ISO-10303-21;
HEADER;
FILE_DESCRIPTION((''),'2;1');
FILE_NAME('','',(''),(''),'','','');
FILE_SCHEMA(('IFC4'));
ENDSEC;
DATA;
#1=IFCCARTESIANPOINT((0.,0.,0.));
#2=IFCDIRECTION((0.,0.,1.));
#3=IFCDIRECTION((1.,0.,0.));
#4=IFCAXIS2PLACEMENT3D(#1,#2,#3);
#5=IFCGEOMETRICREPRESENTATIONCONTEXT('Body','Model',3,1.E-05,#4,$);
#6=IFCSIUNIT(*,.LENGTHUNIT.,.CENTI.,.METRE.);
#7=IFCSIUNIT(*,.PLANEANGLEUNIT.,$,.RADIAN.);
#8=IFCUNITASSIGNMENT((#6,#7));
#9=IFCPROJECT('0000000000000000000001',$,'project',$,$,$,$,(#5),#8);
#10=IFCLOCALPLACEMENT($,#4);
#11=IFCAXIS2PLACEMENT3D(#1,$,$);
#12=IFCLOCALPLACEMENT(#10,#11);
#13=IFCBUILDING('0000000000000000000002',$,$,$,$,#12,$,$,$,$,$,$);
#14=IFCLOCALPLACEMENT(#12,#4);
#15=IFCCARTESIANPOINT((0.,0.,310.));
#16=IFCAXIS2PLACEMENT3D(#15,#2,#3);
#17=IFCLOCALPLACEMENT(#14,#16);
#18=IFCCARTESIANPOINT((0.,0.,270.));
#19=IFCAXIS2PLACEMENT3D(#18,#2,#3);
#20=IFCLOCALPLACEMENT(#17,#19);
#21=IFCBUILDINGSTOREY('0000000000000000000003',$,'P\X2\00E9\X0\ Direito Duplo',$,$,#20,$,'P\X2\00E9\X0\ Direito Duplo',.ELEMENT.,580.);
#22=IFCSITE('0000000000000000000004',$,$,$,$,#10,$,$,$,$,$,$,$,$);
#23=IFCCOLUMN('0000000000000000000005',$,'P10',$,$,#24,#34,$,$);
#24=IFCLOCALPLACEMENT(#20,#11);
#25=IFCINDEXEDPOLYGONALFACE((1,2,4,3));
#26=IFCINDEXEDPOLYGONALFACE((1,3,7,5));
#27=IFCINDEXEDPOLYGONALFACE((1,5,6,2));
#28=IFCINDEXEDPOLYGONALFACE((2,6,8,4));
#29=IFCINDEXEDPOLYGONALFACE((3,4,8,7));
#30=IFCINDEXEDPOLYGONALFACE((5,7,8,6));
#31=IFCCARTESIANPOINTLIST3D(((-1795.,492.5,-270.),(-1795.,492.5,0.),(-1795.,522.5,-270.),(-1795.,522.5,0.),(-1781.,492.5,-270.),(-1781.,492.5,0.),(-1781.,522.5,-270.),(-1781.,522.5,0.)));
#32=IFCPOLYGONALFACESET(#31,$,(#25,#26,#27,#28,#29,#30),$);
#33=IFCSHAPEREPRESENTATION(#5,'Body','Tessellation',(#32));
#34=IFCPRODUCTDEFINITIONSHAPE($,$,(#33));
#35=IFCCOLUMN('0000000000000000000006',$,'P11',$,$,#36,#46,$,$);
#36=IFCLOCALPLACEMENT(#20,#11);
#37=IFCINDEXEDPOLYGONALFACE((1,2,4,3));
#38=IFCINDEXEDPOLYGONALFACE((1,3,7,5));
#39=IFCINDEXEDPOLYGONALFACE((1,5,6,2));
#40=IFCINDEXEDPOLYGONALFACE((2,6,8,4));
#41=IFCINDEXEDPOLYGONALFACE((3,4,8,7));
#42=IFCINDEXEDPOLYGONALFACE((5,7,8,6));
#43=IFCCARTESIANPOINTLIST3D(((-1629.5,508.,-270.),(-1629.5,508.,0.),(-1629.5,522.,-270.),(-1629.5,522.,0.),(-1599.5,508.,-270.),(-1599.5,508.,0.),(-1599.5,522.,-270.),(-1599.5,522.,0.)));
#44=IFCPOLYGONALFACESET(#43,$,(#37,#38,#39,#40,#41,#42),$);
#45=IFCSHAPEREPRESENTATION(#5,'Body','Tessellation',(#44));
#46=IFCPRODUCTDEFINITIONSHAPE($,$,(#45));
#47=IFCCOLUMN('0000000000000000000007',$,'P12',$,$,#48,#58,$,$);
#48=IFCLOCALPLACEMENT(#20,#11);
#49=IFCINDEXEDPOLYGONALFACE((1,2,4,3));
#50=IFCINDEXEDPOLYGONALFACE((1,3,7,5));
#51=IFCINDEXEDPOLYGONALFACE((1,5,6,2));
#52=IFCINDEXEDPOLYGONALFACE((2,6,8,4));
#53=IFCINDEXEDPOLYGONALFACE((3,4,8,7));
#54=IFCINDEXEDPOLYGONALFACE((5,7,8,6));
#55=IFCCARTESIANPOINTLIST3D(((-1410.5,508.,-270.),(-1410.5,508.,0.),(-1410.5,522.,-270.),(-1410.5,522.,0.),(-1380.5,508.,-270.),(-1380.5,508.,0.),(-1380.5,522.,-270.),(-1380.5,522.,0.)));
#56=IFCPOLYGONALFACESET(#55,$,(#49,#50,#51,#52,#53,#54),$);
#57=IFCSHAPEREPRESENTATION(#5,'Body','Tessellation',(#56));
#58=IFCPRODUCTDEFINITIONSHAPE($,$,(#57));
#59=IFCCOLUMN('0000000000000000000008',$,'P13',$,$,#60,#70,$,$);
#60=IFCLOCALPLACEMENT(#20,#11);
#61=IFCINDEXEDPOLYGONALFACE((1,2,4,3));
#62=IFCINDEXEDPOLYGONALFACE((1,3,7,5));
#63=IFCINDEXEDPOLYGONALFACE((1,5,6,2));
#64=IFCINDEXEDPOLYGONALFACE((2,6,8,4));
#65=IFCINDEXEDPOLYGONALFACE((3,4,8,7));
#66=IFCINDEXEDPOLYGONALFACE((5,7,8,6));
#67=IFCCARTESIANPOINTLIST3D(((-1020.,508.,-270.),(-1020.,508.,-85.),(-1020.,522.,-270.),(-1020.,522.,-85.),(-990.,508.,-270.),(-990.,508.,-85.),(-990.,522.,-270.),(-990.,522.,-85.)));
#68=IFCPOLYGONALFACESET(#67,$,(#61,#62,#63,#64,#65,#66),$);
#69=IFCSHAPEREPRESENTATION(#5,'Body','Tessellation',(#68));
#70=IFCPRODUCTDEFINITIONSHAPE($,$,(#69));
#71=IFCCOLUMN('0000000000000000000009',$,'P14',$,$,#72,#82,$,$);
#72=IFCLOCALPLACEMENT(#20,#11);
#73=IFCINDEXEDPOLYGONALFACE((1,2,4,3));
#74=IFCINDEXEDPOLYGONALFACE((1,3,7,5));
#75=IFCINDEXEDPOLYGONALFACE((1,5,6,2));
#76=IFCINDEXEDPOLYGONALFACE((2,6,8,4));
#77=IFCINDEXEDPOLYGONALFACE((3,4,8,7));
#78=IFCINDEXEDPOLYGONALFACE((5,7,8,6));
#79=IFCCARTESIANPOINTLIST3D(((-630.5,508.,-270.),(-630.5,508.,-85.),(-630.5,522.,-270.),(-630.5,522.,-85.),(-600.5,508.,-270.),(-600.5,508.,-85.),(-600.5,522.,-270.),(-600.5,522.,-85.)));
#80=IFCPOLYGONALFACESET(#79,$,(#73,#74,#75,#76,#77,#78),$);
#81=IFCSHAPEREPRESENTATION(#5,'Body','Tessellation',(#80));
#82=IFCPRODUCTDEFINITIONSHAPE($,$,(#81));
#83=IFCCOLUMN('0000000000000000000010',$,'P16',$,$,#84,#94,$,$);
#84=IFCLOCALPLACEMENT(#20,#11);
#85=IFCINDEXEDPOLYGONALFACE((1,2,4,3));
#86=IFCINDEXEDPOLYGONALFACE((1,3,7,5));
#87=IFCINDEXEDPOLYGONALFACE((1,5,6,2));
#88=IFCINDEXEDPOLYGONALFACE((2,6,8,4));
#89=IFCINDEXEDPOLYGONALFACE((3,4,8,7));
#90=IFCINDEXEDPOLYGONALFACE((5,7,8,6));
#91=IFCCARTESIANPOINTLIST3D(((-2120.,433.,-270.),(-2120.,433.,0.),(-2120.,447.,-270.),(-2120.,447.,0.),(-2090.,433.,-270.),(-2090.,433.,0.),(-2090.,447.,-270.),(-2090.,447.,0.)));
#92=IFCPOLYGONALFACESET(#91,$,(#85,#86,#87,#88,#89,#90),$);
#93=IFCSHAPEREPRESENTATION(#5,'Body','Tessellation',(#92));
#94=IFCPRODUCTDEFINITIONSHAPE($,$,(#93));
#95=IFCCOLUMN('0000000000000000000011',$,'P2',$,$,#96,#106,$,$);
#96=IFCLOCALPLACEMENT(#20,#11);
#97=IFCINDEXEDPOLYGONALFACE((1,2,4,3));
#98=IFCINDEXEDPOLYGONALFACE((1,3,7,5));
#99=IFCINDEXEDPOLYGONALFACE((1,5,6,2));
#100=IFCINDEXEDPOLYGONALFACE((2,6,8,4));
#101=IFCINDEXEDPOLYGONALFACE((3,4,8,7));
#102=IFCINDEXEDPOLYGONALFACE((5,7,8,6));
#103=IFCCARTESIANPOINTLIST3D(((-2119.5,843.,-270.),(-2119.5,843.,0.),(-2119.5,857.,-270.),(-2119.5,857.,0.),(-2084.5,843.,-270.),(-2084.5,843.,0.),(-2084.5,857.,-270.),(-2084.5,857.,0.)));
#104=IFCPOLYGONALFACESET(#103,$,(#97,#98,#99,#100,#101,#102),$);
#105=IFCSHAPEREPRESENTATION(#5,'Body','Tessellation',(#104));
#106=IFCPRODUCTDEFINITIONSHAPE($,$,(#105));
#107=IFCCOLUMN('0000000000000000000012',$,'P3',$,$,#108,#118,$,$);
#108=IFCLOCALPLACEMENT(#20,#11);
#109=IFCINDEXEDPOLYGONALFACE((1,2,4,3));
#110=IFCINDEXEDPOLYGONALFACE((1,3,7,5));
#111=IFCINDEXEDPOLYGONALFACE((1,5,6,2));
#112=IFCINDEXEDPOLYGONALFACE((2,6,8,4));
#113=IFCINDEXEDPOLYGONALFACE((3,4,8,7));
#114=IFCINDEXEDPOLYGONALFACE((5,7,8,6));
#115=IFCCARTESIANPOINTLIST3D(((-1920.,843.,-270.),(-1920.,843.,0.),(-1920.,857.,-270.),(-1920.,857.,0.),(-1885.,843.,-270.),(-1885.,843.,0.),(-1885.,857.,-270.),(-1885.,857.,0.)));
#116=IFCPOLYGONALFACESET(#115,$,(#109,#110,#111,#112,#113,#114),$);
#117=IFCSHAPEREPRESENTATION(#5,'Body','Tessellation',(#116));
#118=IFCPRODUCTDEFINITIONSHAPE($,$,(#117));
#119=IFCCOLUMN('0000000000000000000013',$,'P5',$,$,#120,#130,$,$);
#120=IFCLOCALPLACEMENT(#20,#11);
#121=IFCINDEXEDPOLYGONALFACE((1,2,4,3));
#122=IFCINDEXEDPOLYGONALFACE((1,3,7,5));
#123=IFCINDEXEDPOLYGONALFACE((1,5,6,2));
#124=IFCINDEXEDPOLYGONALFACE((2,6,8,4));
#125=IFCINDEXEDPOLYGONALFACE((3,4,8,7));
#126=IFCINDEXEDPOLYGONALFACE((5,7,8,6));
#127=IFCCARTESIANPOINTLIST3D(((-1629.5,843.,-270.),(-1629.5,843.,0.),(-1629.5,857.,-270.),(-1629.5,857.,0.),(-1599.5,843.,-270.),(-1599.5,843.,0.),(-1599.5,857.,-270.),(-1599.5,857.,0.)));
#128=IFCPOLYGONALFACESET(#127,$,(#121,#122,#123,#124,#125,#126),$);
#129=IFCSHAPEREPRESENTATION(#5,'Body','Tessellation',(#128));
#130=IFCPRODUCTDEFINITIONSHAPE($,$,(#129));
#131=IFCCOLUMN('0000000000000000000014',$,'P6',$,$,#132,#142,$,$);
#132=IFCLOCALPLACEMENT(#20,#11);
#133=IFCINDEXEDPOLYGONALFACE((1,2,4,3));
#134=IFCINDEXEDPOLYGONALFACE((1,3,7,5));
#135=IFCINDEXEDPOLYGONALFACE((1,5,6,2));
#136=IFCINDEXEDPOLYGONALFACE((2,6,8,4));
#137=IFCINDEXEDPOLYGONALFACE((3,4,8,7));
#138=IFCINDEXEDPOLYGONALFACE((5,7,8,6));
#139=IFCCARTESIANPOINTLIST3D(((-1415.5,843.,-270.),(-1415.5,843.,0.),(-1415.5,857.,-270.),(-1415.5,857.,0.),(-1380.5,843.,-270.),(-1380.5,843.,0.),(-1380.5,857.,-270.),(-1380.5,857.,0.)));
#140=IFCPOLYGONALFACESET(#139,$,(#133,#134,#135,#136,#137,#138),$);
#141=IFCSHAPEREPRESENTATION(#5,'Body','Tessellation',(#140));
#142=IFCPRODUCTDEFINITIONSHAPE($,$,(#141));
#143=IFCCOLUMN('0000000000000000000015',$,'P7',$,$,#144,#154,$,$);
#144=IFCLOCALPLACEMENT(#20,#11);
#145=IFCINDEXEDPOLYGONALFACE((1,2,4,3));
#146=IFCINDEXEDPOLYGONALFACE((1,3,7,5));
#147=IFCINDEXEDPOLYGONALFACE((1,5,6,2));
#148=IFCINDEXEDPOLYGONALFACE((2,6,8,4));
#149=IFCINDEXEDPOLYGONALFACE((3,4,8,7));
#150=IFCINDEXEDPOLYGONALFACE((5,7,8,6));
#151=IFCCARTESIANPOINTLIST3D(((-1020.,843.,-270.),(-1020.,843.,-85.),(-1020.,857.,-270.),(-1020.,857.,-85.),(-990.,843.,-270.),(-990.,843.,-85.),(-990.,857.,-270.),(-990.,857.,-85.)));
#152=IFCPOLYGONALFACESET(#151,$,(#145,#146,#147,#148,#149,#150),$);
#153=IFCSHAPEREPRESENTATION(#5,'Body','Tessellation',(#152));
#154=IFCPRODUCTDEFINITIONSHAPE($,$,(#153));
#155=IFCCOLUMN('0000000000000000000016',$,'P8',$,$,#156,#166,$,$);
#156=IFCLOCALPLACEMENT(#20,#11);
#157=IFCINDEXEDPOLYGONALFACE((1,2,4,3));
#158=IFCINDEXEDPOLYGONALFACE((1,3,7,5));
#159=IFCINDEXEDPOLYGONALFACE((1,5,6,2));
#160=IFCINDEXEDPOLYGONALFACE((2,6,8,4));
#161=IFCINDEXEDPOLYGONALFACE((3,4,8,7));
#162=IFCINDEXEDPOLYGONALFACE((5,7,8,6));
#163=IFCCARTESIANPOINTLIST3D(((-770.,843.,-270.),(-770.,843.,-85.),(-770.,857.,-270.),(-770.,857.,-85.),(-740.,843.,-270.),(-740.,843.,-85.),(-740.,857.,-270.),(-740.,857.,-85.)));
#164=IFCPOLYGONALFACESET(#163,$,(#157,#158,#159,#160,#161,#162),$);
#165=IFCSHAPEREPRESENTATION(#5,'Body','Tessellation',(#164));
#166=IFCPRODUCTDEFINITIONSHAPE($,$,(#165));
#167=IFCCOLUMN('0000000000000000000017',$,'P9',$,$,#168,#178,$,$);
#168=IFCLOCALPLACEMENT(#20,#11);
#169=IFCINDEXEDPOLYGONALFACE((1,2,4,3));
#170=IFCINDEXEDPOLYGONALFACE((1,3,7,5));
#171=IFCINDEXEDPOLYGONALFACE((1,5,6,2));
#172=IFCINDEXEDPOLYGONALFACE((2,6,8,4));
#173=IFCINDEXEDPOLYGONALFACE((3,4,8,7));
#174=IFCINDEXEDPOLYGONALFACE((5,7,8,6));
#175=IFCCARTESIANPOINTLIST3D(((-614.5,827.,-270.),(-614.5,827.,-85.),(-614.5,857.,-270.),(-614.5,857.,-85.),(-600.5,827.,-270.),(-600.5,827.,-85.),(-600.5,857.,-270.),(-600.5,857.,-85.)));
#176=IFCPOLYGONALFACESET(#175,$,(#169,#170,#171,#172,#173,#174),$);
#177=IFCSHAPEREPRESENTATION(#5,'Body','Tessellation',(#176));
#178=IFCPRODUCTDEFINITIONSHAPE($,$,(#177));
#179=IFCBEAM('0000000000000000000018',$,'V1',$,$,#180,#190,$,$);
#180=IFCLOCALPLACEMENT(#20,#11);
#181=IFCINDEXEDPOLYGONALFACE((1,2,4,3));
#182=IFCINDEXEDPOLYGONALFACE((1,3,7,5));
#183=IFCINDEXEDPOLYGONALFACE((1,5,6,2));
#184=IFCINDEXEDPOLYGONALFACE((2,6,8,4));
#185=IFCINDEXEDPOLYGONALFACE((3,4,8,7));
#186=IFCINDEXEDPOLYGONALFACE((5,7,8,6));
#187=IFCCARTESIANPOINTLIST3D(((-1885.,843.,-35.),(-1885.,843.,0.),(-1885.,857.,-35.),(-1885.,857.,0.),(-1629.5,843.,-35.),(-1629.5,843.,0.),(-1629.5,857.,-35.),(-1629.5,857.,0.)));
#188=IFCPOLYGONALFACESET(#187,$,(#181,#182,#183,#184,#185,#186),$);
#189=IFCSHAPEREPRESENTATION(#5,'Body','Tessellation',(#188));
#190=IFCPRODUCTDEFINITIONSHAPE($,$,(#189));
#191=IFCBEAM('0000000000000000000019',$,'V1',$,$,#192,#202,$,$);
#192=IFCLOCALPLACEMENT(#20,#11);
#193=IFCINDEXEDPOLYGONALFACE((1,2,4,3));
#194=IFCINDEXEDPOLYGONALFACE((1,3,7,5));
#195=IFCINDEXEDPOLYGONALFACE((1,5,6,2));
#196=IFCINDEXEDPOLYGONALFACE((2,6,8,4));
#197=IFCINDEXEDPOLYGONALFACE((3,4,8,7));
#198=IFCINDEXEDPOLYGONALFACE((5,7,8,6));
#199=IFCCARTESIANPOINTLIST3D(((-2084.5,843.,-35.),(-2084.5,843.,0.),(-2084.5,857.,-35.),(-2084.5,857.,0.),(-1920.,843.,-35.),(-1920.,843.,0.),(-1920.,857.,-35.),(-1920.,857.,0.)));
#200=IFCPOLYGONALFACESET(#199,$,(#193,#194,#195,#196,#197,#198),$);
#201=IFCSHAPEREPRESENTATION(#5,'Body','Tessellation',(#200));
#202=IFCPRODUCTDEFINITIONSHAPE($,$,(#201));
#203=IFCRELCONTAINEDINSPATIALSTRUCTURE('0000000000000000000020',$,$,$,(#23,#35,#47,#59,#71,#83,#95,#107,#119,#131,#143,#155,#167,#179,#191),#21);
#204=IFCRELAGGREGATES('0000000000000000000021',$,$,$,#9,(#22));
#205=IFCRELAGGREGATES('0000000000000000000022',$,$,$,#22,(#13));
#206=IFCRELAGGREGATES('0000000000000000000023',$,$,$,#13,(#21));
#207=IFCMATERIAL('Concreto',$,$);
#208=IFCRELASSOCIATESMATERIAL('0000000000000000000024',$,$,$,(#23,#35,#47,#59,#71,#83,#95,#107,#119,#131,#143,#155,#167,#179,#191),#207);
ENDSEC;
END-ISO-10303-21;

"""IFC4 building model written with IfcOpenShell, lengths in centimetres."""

from ifc_helpers import new_model, si_unit, frame, origin, origin_with_axes, origin_2d_with_axis, place, context, project, spatial, rectangle, extrude, material, element, save


model = new_model("IFC4")

# Units and contexts
model_context = context("Model", 3, precision=1e-05, world=origin_with_axes(), identifier="Body")
ifc_project = project(units=[si_unit("LENGTHUNIT", "METRE", prefix="CENTI"), si_unit("PLANEANGLEUNIT", "RADIAN")], contexts=[model_context])

# Site, building, storey
site_placement = place(None, origin_with_axes())
site = spatial("IfcSite", under=ifc_project, at=site_placement)
building_placement = place(site_placement, origin())
building = spatial("IfcBuilding", under=site, at=building_placement)
placement_1 = place(building_placement, origin_with_axes())
placement_2 = place(placement_1, frame((0.0, 0.0, 310.0), z_axis=(0.0, 0.0, 1.0), x_axis=(1.0, 0.0, 0.0)))
storey_placement = place(placement_2, frame((0.0, 0.0, 270.0), z_axis=(0.0, 0.0, 1.0), x_axis=(1.0, 0.0, 0.0)))
storey = spatial("IfcBuildingStorey", under=building, at=storey_placement, Name="Pé Direito Duplo", LongName="Pé Direito Duplo", CompositionType="ELEMENT", Elevation=580.0)

# Columns
ifc_material = material(Name="Concreto")
column_1_placement = place(storey_placement, frame((-1788.0, 507.5, 0.0), z_axis=(0.0, 0.0, 1.0), x_axis=(1.0, 0.0, 0.0)))
element("IfcColumn", 1, at=column_1_placement, inside=storey, material=ifc_material, Name="P10", context=model_context, shape_type="SolidModel", body=[
    extrude(rectangle(XDim=14.0, YDim=30.0, at=origin_2d_with_axis()), origin_with_axes(), (0.0, 0.0, -1.0), 270.0),
])
for number, where, z_axis, x_axis, name in (
    (2, (-1614.5, 515.0, 0.0), (0.0, 0.0, 1.0), (1.0, 0.0, 0.0), "P11"),
    (3, (-1395.5, 515.0, 0.0), (0.0, 0.0, 1.0), (1.0, 0.0, 0.0), "P12"),
):
    element("IfcColumn", number, at=place(storey_placement, frame(where, z_axis=z_axis, x_axis=x_axis)), inside=storey, material=ifc_material, Name=name, context=model_context, shape_type="SolidModel", body=[
        extrude(rectangle(XDim=14.0, YDim=30.0, at=origin_2d_with_axis()), frame((0.0, 0.0, 0.0), z_axis=(0.0, 0.0, 1.0), x_axis=(0.0, 1.0, 0.0)), (0.0, 0.0, -1.0), 270.0),
    ])
for number, where, z_axis, x_axis, name in (
    (4, (-1005.0, 515.0, -85.0), (0.0, 0.0, 1.0), (1.0, 0.0, 0.0), "P13"),
    (5, (-615.5, 515.0, -85.0), (0.0, 0.0, 1.0), (1.0, 0.0, 0.0), "P14"),
):
    element("IfcColumn", number, at=place(storey_placement, frame(where, z_axis=z_axis, x_axis=x_axis)), inside=storey, material=ifc_material, Name=name, context=model_context, shape_type="SolidModel", body=[
        extrude(rectangle(XDim=14.0, YDim=30.0, at=origin_2d_with_axis()), frame((0.0, 0.0, 0.0), z_axis=(0.0, 0.0, 1.0), x_axis=(0.0, -1.0, 0.0)), (0.0, 0.0, -1.0), 185.0),
    ])
column_2_placement = place(storey_placement, frame((-2105.0, 440.0, 0.0), z_axis=(0.0, 0.0, 1.0), x_axis=(1.0, 0.0, 0.0)))
element("IfcColumn", 6, at=column_2_placement, inside=storey, material=ifc_material, Name="P16", context=model_context, shape_type="SolidModel", body=[
    extrude(rectangle(XDim=14.0, YDim=30.0, at=origin_2d_with_axis()), frame((0.0, 0.0, 0.0), z_axis=(0.0, 0.0, 1.0), x_axis=(0.0, 1.0, 0.0)), (0.0, 0.0, -1.0), 270.0),
])
column_3_placement = place(storey_placement, frame((-2102.0, 850.0, 0.0), z_axis=(0.0, 0.0, 1.0), x_axis=(1.0, 0.0, 0.0)))
element("IfcColumn", 7, at=column_3_placement, inside=storey, material=ifc_material, Name="P2", context=model_context, shape_type="SolidModel", body=[
    extrude(rectangle(XDim=14.0, YDim=35.0, at=origin_2d_with_axis()), frame((0.0, 0.0, 0.0), z_axis=(0.0, 0.0, 1.0), x_axis=(0.0, -1.0, 0.0)), (0.0, 0.0, -1.0), 270.0),
])
column_4_placement = place(storey_placement, frame((-1902.5, 850.0, 0.0), z_axis=(0.0, 0.0, 1.0), x_axis=(1.0, 0.0, 0.0)))
element("IfcColumn", 8, at=column_4_placement, inside=storey, material=ifc_material, Name="P3", context=model_context, shape_type="SolidModel", body=[
    extrude(rectangle(XDim=14.0, YDim=35.0, at=origin_2d_with_axis()), frame((0.0, 0.0, 0.0), z_axis=(0.0, 0.0, 1.0), x_axis=(0.0, 1.0, 0.0)), (0.0, 0.0, -1.0), 270.0),
])
column_5_placement = place(storey_placement, frame((-1614.5, 850.0, 0.0), z_axis=(0.0, 0.0, 1.0), x_axis=(1.0, 0.0, 0.0)))
element("IfcColumn", 9, at=column_5_placement, inside=storey, material=ifc_material, Name="P5", context=model_context, shape_type="SolidModel", body=[
    extrude(rectangle(XDim=14.0, YDim=30.0, at=origin_2d_with_axis()), frame((0.0, 0.0, 0.0), z_axis=(0.0, 0.0, 1.0), x_axis=(0.0, -1.0, 0.0)), (0.0, 0.0, -1.0), 270.0),
])
column_6_placement = place(storey_placement, frame((-1398.0, 850.0, 0.0), z_axis=(0.0, 0.0, 1.0), x_axis=(1.0, 0.0, 0.0)))
element("IfcColumn", 10, at=column_6_placement, inside=storey, material=ifc_material, Name="P6", context=model_context, shape_type="SolidModel", body=[
    extrude(rectangle(XDim=14.0, YDim=35.0, at=origin_2d_with_axis()), frame((0.0, 0.0, 0.0), z_axis=(0.0, 0.0, 1.0), x_axis=(0.0, 1.0, 0.0)), (0.0, 0.0, -1.0), 270.0),
])
for number, where, z_axis, x_axis, name in (
    (11, (-1005.0, 850.0, -85.0), (0.0, 0.0, 1.0), (1.0, 0.0, 0.0), "P7"),
    (12, (-755.0, 850.0, -85.0), (0.0, 0.0, 1.0), (1.0, 0.0, 0.0), "P8"),
):
    element("IfcColumn", number, at=place(storey_placement, frame(where, z_axis=z_axis, x_axis=x_axis)), inside=storey, material=ifc_material, Name=name, context=model_context, shape_type="SolidModel", body=[
        extrude(rectangle(XDim=14.0, YDim=30.0, at=origin_2d_with_axis()), frame((0.0, 0.0, 0.0), z_axis=(0.0, 0.0, 1.0), x_axis=(0.0, 1.0, 0.0)), (0.0, 0.0, -1.0), 185.0),
    ])
column_7_placement = place(storey_placement, frame((-607.5, 842.0, -85.0), z_axis=(0.0, 0.0, 1.0), x_axis=(1.0, 0.0, 0.0)))
element("IfcColumn", 13, at=column_7_placement, inside=storey, material=ifc_material, Name="P9", context=model_context, shape_type="SolidModel", body=[
    extrude(rectangle(XDim=14.0, YDim=30.0, at=origin_2d_with_axis()), frame((0.0, 0.0, 0.0), z_axis=(0.0, 0.0, 1.0), x_axis=(-1.0, 0.0, 0.0)), (0.0, 0.0, -1.0), 185.0),
])

# Beams
beam_1_placement = place(storey_placement, frame((-1757.25, 850.0, 0.0), z_axis=(0.0, 0.0, 1.0), x_axis=(1.0, 0.0, 0.0)))
element("IfcBeam", 14, at=beam_1_placement, inside=storey, material=ifc_material, Name="V1", context=model_context, shape_type="SolidModel", body=[
    extrude(rectangle(XDim=14.0, YDim=35.0, at=origin_2d_with_axis()), frame((-127.75, 0.0, -17.5), z_axis=(1.0, 0.0, 0.0), x_axis=(0.0, -1.0, 0.0)), (0.0, 0.0, 1.0), 255.5),
])
beam_2_placement = place(storey_placement, frame((-2002.25, 850.0, 0.0), z_axis=(0.0, 0.0, 1.0), x_axis=(1.0, 0.0, 0.0)))
element("IfcBeam", 15, at=beam_2_placement, inside=storey, material=ifc_material, Name="V1", context=model_context, shape_type="SolidModel", body=[
    extrude(rectangle(XDim=14.0, YDim=35.0, at=origin_2d_with_axis()), frame((-82.25, 0.0, -17.5), z_axis=(1.0, 0.0, 0.0), x_axis=(0.0, -1.0, 0.0)), (0.0, 0.0, 1.0), 164.5),
])

save(model, "model.ifc")
